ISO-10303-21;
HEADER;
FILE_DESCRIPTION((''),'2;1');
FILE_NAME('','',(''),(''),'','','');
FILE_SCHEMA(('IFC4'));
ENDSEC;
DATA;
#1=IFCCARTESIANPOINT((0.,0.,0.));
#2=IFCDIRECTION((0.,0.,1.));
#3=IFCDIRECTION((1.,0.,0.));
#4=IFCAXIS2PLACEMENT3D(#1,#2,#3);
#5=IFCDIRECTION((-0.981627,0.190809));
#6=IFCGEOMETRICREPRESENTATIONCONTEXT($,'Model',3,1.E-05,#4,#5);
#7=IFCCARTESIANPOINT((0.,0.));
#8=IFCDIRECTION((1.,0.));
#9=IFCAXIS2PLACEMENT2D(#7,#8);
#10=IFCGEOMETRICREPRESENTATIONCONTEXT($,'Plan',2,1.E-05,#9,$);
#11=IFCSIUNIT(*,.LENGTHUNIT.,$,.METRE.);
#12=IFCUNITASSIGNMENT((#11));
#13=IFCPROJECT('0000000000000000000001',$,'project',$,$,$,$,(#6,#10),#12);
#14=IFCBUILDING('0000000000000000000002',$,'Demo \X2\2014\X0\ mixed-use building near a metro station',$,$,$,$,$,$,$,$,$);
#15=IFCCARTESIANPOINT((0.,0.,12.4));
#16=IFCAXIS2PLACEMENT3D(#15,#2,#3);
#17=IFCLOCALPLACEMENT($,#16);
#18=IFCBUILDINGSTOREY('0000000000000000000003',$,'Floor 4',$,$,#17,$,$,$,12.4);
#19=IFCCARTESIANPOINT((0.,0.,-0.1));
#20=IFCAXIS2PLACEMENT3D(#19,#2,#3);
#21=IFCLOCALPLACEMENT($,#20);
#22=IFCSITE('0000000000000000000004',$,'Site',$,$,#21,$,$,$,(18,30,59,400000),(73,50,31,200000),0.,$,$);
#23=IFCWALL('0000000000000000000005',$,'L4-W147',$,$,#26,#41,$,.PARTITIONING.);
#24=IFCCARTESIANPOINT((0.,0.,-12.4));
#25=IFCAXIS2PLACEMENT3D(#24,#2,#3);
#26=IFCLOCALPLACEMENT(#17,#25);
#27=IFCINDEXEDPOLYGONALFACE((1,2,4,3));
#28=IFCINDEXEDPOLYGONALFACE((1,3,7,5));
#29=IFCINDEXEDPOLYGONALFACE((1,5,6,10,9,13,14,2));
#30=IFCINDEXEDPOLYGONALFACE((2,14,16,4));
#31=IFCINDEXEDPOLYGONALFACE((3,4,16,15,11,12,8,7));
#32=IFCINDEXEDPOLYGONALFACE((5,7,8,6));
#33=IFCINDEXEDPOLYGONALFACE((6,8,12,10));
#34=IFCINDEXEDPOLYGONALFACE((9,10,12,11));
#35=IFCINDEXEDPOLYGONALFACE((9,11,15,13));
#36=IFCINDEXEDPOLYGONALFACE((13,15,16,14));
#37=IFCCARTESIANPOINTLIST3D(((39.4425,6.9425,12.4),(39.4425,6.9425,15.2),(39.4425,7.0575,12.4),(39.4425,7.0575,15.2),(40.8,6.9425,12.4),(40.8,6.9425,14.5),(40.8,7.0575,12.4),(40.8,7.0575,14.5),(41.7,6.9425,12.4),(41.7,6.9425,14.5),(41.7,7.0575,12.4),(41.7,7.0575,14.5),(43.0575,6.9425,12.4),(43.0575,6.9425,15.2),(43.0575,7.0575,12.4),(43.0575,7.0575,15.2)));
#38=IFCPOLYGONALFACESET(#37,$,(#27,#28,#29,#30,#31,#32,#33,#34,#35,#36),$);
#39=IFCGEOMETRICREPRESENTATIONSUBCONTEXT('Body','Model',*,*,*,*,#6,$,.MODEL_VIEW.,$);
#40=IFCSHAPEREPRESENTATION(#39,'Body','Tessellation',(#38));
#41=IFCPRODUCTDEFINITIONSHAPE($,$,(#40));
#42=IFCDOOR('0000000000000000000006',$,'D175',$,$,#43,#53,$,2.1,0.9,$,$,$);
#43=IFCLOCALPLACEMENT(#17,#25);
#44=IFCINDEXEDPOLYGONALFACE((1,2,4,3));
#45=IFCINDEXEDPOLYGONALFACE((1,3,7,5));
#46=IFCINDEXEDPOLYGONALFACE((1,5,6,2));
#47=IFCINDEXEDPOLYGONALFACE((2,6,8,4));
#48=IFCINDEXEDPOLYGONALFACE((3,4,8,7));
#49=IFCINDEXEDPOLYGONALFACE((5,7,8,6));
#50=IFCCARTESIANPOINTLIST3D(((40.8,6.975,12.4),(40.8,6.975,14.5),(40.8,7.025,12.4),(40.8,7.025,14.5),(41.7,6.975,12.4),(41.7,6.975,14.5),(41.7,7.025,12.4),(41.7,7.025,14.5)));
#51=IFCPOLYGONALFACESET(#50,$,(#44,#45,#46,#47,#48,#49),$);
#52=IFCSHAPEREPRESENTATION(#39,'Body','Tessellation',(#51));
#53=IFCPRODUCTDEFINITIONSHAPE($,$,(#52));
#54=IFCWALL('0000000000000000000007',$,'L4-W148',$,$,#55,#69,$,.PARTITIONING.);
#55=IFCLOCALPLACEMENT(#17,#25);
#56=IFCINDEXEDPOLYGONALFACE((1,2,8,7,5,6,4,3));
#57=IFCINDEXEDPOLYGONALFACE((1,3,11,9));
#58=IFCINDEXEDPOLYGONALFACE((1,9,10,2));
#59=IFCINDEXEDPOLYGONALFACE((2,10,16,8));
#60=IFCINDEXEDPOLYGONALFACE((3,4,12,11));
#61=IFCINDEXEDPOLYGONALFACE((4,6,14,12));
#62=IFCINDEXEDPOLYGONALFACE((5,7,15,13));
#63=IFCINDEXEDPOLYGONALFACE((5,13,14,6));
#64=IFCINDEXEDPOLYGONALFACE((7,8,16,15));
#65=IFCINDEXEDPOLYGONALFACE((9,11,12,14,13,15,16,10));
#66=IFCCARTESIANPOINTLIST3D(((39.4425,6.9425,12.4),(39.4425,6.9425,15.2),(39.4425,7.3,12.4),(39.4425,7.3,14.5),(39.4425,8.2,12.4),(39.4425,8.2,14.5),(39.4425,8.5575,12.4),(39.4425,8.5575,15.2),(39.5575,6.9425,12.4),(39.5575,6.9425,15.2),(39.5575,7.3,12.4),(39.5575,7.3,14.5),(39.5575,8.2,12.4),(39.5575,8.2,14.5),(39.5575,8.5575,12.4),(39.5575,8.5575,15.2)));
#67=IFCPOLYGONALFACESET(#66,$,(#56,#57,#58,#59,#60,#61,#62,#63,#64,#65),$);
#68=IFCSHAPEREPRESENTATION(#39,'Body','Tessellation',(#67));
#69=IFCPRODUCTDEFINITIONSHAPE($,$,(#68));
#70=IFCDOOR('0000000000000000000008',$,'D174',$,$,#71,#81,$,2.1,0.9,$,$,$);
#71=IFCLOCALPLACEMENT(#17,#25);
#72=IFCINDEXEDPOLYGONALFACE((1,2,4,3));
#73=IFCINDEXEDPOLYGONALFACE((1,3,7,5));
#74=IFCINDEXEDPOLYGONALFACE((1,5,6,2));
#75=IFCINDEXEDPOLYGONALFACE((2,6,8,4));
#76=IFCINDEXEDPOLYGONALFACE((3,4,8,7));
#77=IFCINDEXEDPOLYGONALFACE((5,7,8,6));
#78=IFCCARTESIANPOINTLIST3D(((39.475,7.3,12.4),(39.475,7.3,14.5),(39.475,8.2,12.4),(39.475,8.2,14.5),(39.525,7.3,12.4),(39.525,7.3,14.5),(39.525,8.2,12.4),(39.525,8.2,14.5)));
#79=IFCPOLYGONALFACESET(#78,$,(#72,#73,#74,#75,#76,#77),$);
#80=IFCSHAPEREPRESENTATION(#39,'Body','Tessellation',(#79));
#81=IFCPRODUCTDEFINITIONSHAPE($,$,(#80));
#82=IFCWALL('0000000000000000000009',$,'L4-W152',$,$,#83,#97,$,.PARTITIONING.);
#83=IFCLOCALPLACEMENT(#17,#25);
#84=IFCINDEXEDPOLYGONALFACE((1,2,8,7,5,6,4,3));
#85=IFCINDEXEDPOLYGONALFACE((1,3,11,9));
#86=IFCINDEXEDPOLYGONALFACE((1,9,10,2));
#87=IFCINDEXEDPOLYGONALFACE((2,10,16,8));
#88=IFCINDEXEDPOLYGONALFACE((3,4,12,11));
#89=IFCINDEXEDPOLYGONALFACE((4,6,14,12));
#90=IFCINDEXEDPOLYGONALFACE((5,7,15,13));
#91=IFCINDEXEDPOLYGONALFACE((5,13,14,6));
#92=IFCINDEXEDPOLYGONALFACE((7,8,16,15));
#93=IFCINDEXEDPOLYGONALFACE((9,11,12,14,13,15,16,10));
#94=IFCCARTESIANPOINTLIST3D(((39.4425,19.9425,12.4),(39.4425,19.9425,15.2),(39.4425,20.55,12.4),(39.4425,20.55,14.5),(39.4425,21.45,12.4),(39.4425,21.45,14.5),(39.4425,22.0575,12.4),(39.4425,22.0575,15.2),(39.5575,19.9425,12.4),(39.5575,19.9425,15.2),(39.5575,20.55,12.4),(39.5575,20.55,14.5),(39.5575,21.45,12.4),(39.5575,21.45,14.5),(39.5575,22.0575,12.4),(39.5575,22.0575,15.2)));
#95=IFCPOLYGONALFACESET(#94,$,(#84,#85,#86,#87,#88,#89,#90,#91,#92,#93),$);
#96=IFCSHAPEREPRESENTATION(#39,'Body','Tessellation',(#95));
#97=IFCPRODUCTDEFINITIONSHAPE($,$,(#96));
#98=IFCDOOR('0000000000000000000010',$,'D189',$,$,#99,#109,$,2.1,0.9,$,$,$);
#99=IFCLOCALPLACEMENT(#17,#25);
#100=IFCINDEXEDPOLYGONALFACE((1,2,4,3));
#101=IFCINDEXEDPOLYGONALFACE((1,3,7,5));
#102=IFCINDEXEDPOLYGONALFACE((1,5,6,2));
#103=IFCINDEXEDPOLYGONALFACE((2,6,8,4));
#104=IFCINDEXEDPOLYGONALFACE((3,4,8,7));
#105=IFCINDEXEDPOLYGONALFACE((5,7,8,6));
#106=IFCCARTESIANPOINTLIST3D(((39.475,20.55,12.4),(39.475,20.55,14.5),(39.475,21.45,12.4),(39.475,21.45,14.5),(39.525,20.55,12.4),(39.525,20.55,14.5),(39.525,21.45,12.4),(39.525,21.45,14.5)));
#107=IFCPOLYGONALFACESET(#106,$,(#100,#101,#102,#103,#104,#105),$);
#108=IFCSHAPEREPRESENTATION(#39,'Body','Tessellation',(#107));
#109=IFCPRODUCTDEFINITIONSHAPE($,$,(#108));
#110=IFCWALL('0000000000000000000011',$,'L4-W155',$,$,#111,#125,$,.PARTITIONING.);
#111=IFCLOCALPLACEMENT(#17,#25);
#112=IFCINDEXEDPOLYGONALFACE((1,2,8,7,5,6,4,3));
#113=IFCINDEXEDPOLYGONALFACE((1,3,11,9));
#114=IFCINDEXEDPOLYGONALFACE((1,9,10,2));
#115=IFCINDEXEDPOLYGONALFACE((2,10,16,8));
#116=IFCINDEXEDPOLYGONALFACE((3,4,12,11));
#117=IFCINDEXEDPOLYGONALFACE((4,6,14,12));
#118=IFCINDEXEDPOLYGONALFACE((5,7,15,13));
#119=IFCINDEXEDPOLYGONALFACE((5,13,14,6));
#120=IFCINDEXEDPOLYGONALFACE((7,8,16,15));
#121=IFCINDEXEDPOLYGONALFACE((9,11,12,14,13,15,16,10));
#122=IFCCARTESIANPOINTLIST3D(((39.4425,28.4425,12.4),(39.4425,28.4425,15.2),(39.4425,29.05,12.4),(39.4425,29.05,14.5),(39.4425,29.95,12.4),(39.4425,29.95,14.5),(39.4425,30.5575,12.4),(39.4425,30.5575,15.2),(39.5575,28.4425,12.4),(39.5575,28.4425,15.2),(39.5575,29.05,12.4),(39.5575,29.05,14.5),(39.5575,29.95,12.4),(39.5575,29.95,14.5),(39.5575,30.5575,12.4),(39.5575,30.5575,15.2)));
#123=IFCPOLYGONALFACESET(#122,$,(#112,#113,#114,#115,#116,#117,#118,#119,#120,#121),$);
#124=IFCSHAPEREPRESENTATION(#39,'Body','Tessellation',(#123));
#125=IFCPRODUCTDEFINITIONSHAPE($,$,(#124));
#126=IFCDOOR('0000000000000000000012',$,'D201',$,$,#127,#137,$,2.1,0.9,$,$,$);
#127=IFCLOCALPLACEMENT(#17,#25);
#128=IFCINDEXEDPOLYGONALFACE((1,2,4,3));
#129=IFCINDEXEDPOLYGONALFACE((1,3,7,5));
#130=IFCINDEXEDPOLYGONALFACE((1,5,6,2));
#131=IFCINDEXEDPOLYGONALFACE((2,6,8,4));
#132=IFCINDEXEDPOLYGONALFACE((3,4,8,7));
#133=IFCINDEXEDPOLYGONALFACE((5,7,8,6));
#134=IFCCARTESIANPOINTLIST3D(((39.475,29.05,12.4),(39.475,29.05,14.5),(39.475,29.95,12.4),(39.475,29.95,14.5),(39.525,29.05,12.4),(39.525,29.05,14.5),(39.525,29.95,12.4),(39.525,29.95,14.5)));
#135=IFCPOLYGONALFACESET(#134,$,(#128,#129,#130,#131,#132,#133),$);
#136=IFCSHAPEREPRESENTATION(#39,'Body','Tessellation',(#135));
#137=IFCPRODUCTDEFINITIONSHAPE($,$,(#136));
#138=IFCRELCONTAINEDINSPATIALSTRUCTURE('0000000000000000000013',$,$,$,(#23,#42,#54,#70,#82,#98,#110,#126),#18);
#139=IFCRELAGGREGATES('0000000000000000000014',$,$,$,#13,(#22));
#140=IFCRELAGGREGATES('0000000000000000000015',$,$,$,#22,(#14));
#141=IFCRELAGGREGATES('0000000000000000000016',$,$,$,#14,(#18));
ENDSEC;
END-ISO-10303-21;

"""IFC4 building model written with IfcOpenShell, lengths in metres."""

from ifc_helpers import new_model, si_unit, direction, frame, origin_with_axes, origin_2d_with_axis, place, context, subcontext, project, spatial, line, indexed_curve, outline, extrude, element, fill, save


model = new_model("IFC4")

# Units and contexts
model_context = context("Model", 3, precision=1e-05, world=origin_with_axes(), true_north=direction((-0.981627, 0.190809)))
plan_context = context("Plan", 2, precision=1e-05, world=origin_2d_with_axis())
body_context = subcontext(model_context, "Body", "Model", "MODEL_VIEW")
ifc_project = project(units=[si_unit("LENGTHUNIT", "METRE")], contexts=[model_context, plan_context])

# Site, building, storey
site_placement = place(None, frame((0.0, 0.0, -0.1), z_axis=(0.0, 0.0, 1.0), x_axis=(1.0, 0.0, 0.0)))
site = spatial("IfcSite", under=ifc_project, at=site_placement, Name="Site", RefLatitude=(18, 30, 59, 400000), RefLongitude=(73, 50, 31, 200000), RefElevation=0.0)
building = spatial("IfcBuilding", under=site, Name="Demo — mixed-use building near a metro station")
storey_placement = place(None, frame((0.0, 0.0, 12.4), z_axis=(0.0, 0.0, 1.0), x_axis=(1.0, 0.0, 0.0)))
storey = spatial("IfcBuildingStorey", under=building, at=storey_placement, Name="Floor 4", Elevation=12.4)

# Walls, openings, doors
wall_1_placement = place(storey_placement, frame((0.0, 0.0, -12.4), z_axis=(0.0, 0.0, 1.0), x_axis=(1.0, 0.0, 0.0)))
wall_1 = element("IfcWall", 1, at=wall_1_placement, inside=storey, Name="L4-W147", PredefinedType="PARTITIONING", context=body_context, shape_type="SweptSolid", body=[
    extrude(outline(indexed_curve([(43.0575, 6.9425), (39.4425, 6.9425), (39.4425, 7.0575), (43.0575, 7.0575)], segments=[line(1, 2, 3, 4, 1)])), frame((0.0, 0.0, 12.4), z_axis=(0.0, 0.0, 1.0), x_axis=(1.0, 0.0, 0.0)), (0.0, 0.0, 1.0), 2.8),
])
opening_1_placement = place(wall_1_placement, origin_with_axes())
opening_1 = element("IfcOpeningElement", 2, at=opening_1_placement, cuts=wall_1, context=body_context, shape_type="SweptSolid", body=[
    extrude(outline(indexed_curve([(41.7, 6.8925), (40.8, 6.8925), (40.8, 7.1075), (41.7, 7.1075)], segments=[line(1, 2, 3, 4, 1)])), frame((0.0, 0.0, 12.4), z_axis=(0.0, 0.0, 1.0), x_axis=(1.0, 0.0, 0.0)), (0.0, 0.0, 1.0), 2.1),
])
door_1_placement = place(storey_placement, frame((0.0, 0.0, -12.4), z_axis=(0.0, 0.0, 1.0), x_axis=(1.0, 0.0, 0.0)))
door_1 = element("IfcDoor", 3, at=door_1_placement, inside=storey, Name="D175", OverallHeight=2.1, OverallWidth=0.9, context=body_context, shape_type="SweptSolid", body=[
    extrude(outline(indexed_curve([(41.7, 6.975), (40.8, 6.975), (40.8, 7.025), (41.7, 7.025)], segments=[line(1, 2, 3, 4, 1)])), frame((0.0, 0.0, 12.4), z_axis=(0.0, 0.0, 1.0), x_axis=(1.0, 0.0, 0.0)), (0.0, 0.0, 1.0), 2.1),
])
fill(opening_1, door_1)
wall_2_placement = place(storey_placement, frame((0.0, 0.0, -12.4), z_axis=(0.0, 0.0, 1.0), x_axis=(1.0, 0.0, 0.0)))
wall_2 = element("IfcWall", 4, at=wall_2_placement, inside=storey, Name="L4-W148", PredefinedType="PARTITIONING", context=body_context, shape_type="SweptSolid", body=[
    extrude(outline(indexed_curve([(39.5575, 8.5575), (39.5575, 6.9425), (39.4425, 6.9425), (39.4425, 8.5575)], segments=[line(1, 2, 3, 4, 1)])), frame((0.0, 0.0, 12.4), z_axis=(0.0, 0.0, 1.0), x_axis=(1.0, 0.0, 0.0)), (0.0, 0.0, 1.0), 2.8),
])
opening_2_placement = place(wall_2_placement, origin_with_axes())
opening_2 = element("IfcOpeningElement", 5, at=opening_2_placement, cuts=wall_2, context=body_context, shape_type="SweptSolid", body=[
    extrude(outline(indexed_curve([(39.6075, 8.2), (39.6075, 7.3), (39.3925, 7.3), (39.3925, 8.2)], segments=[line(1, 2, 3, 4, 1)])), frame((0.0, 0.0, 12.4), z_axis=(0.0, 0.0, 1.0), x_axis=(1.0, 0.0, 0.0)), (0.0, 0.0, 1.0), 2.1),
])
door_2_placement = place(storey_placement, frame((0.0, 0.0, -12.4), z_axis=(0.0, 0.0, 1.0), x_axis=(1.0, 0.0, 0.0)))
door_2 = element("IfcDoor", 6, at=door_2_placement, inside=storey, Name="D174", OverallHeight=2.1, OverallWidth=0.9, context=body_context, shape_type="SweptSolid", body=[
    extrude(outline(indexed_curve([(39.525, 8.2), (39.525, 7.3), (39.475, 7.3), (39.475, 8.2)], segments=[line(1, 2, 3, 4, 1)])), frame((0.0, 0.0, 12.4), z_axis=(0.0, 0.0, 1.0), x_axis=(1.0, 0.0, 0.0)), (0.0, 0.0, 1.0), 2.1),
])
fill(opening_2, door_2)

# Wall, opening, door
wall_3_placement = place(storey_placement, frame((0.0, 0.0, -12.4), z_axis=(0.0, 0.0, 1.0), x_axis=(1.0, 0.0, 0.0)))
wall_3 = element("IfcWall", 7, at=wall_3_placement, inside=storey, Name="L4-W152", PredefinedType="PARTITIONING", context=body_context, shape_type="SweptSolid", body=[
    extrude(outline(indexed_curve([(39.5575, 22.0575), (39.5575, 19.9425), (39.4425, 19.9425), (39.4425, 22.0575)], segments=[line(1, 2, 3, 4, 1)])), frame((0.0, 0.0, 12.4), z_axis=(0.0, 0.0, 1.0), x_axis=(1.0, 0.0, 0.0)), (0.0, 0.0, 1.0), 2.8),
])
opening_3_placement = place(wall_3_placement, origin_with_axes())
opening_3 = element("IfcOpeningElement", 8, at=opening_3_placement, cuts=wall_3, context=body_context, shape_type="SweptSolid", body=[
    extrude(outline(indexed_curve([(39.6075, 21.45), (39.6075, 20.55), (39.3925, 20.55), (39.3925, 21.45)], segments=[line(1, 2, 3, 4, 1)])), frame((0.0, 0.0, 12.4), z_axis=(0.0, 0.0, 1.0), x_axis=(1.0, 0.0, 0.0)), (0.0, 0.0, 1.0), 2.1),
])
door_3_placement = place(storey_placement, frame((0.0, 0.0, -12.4), z_axis=(0.0, 0.0, 1.0), x_axis=(1.0, 0.0, 0.0)))
door_3 = element("IfcDoor", 9, at=door_3_placement, inside=storey, Name="D189", OverallHeight=2.1, OverallWidth=0.9, context=body_context, shape_type="SweptSolid", body=[
    extrude(outline(indexed_curve([(39.525, 21.45), (39.525, 20.55), (39.475, 20.55), (39.475, 21.45)], segments=[line(1, 2, 3, 4, 1)])), frame((0.0, 0.0, 12.4), z_axis=(0.0, 0.0, 1.0), x_axis=(1.0, 0.0, 0.0)), (0.0, 0.0, 1.0), 2.1),
])
fill(opening_3, door_3)

# Wall, opening, door
wall_4_placement = place(storey_placement, frame((0.0, 0.0, -12.4), z_axis=(0.0, 0.0, 1.0), x_axis=(1.0, 0.0, 0.0)))
wall_4 = element("IfcWall", 10, at=wall_4_placement, inside=storey, Name="L4-W155", PredefinedType="PARTITIONING", context=body_context, shape_type="SweptSolid", body=[
    extrude(outline(indexed_curve([(39.5575, 30.5575), (39.5575, 28.4425), (39.4425, 28.4425), (39.4425, 30.5575)], segments=[line(1, 2, 3, 4, 1)])), frame((0.0, 0.0, 12.4), z_axis=(0.0, 0.0, 1.0), x_axis=(1.0, 0.0, 0.0)), (0.0, 0.0, 1.0), 2.8),
])
opening_4_placement = place(wall_4_placement, origin_with_axes())
opening_4 = element("IfcOpeningElement", 11, at=opening_4_placement, cuts=wall_4, context=body_context, shape_type="SweptSolid", body=[
    extrude(outline(indexed_curve([(39.6075, 29.95), (39.6075, 29.05), (39.3925, 29.05), (39.3925, 29.95)], segments=[line(1, 2, 3, 4, 1)])), frame((0.0, 0.0, 12.4), z_axis=(0.0, 0.0, 1.0), x_axis=(1.0, 0.0, 0.0)), (0.0, 0.0, 1.0), 2.1),
])
door_4_placement = place(storey_placement, frame((0.0, 0.0, -12.4), z_axis=(0.0, 0.0, 1.0), x_axis=(1.0, 0.0, 0.0)))
door_4 = element("IfcDoor", 12, at=door_4_placement, inside=storey, Name="D201", OverallHeight=2.1, OverallWidth=0.9, context=body_context, shape_type="SweptSolid", body=[
    extrude(outline(indexed_curve([(39.525, 29.95), (39.525, 29.05), (39.475, 29.05), (39.475, 29.95)], segments=[line(1, 2, 3, 4, 1)])), frame((0.0, 0.0, 12.4), z_axis=(0.0, 0.0, 1.0), x_axis=(1.0, 0.0, 0.0)), (0.0, 0.0, 1.0), 2.1),
])
fill(opening_4, door_4)

save(model, "model.ifc")
